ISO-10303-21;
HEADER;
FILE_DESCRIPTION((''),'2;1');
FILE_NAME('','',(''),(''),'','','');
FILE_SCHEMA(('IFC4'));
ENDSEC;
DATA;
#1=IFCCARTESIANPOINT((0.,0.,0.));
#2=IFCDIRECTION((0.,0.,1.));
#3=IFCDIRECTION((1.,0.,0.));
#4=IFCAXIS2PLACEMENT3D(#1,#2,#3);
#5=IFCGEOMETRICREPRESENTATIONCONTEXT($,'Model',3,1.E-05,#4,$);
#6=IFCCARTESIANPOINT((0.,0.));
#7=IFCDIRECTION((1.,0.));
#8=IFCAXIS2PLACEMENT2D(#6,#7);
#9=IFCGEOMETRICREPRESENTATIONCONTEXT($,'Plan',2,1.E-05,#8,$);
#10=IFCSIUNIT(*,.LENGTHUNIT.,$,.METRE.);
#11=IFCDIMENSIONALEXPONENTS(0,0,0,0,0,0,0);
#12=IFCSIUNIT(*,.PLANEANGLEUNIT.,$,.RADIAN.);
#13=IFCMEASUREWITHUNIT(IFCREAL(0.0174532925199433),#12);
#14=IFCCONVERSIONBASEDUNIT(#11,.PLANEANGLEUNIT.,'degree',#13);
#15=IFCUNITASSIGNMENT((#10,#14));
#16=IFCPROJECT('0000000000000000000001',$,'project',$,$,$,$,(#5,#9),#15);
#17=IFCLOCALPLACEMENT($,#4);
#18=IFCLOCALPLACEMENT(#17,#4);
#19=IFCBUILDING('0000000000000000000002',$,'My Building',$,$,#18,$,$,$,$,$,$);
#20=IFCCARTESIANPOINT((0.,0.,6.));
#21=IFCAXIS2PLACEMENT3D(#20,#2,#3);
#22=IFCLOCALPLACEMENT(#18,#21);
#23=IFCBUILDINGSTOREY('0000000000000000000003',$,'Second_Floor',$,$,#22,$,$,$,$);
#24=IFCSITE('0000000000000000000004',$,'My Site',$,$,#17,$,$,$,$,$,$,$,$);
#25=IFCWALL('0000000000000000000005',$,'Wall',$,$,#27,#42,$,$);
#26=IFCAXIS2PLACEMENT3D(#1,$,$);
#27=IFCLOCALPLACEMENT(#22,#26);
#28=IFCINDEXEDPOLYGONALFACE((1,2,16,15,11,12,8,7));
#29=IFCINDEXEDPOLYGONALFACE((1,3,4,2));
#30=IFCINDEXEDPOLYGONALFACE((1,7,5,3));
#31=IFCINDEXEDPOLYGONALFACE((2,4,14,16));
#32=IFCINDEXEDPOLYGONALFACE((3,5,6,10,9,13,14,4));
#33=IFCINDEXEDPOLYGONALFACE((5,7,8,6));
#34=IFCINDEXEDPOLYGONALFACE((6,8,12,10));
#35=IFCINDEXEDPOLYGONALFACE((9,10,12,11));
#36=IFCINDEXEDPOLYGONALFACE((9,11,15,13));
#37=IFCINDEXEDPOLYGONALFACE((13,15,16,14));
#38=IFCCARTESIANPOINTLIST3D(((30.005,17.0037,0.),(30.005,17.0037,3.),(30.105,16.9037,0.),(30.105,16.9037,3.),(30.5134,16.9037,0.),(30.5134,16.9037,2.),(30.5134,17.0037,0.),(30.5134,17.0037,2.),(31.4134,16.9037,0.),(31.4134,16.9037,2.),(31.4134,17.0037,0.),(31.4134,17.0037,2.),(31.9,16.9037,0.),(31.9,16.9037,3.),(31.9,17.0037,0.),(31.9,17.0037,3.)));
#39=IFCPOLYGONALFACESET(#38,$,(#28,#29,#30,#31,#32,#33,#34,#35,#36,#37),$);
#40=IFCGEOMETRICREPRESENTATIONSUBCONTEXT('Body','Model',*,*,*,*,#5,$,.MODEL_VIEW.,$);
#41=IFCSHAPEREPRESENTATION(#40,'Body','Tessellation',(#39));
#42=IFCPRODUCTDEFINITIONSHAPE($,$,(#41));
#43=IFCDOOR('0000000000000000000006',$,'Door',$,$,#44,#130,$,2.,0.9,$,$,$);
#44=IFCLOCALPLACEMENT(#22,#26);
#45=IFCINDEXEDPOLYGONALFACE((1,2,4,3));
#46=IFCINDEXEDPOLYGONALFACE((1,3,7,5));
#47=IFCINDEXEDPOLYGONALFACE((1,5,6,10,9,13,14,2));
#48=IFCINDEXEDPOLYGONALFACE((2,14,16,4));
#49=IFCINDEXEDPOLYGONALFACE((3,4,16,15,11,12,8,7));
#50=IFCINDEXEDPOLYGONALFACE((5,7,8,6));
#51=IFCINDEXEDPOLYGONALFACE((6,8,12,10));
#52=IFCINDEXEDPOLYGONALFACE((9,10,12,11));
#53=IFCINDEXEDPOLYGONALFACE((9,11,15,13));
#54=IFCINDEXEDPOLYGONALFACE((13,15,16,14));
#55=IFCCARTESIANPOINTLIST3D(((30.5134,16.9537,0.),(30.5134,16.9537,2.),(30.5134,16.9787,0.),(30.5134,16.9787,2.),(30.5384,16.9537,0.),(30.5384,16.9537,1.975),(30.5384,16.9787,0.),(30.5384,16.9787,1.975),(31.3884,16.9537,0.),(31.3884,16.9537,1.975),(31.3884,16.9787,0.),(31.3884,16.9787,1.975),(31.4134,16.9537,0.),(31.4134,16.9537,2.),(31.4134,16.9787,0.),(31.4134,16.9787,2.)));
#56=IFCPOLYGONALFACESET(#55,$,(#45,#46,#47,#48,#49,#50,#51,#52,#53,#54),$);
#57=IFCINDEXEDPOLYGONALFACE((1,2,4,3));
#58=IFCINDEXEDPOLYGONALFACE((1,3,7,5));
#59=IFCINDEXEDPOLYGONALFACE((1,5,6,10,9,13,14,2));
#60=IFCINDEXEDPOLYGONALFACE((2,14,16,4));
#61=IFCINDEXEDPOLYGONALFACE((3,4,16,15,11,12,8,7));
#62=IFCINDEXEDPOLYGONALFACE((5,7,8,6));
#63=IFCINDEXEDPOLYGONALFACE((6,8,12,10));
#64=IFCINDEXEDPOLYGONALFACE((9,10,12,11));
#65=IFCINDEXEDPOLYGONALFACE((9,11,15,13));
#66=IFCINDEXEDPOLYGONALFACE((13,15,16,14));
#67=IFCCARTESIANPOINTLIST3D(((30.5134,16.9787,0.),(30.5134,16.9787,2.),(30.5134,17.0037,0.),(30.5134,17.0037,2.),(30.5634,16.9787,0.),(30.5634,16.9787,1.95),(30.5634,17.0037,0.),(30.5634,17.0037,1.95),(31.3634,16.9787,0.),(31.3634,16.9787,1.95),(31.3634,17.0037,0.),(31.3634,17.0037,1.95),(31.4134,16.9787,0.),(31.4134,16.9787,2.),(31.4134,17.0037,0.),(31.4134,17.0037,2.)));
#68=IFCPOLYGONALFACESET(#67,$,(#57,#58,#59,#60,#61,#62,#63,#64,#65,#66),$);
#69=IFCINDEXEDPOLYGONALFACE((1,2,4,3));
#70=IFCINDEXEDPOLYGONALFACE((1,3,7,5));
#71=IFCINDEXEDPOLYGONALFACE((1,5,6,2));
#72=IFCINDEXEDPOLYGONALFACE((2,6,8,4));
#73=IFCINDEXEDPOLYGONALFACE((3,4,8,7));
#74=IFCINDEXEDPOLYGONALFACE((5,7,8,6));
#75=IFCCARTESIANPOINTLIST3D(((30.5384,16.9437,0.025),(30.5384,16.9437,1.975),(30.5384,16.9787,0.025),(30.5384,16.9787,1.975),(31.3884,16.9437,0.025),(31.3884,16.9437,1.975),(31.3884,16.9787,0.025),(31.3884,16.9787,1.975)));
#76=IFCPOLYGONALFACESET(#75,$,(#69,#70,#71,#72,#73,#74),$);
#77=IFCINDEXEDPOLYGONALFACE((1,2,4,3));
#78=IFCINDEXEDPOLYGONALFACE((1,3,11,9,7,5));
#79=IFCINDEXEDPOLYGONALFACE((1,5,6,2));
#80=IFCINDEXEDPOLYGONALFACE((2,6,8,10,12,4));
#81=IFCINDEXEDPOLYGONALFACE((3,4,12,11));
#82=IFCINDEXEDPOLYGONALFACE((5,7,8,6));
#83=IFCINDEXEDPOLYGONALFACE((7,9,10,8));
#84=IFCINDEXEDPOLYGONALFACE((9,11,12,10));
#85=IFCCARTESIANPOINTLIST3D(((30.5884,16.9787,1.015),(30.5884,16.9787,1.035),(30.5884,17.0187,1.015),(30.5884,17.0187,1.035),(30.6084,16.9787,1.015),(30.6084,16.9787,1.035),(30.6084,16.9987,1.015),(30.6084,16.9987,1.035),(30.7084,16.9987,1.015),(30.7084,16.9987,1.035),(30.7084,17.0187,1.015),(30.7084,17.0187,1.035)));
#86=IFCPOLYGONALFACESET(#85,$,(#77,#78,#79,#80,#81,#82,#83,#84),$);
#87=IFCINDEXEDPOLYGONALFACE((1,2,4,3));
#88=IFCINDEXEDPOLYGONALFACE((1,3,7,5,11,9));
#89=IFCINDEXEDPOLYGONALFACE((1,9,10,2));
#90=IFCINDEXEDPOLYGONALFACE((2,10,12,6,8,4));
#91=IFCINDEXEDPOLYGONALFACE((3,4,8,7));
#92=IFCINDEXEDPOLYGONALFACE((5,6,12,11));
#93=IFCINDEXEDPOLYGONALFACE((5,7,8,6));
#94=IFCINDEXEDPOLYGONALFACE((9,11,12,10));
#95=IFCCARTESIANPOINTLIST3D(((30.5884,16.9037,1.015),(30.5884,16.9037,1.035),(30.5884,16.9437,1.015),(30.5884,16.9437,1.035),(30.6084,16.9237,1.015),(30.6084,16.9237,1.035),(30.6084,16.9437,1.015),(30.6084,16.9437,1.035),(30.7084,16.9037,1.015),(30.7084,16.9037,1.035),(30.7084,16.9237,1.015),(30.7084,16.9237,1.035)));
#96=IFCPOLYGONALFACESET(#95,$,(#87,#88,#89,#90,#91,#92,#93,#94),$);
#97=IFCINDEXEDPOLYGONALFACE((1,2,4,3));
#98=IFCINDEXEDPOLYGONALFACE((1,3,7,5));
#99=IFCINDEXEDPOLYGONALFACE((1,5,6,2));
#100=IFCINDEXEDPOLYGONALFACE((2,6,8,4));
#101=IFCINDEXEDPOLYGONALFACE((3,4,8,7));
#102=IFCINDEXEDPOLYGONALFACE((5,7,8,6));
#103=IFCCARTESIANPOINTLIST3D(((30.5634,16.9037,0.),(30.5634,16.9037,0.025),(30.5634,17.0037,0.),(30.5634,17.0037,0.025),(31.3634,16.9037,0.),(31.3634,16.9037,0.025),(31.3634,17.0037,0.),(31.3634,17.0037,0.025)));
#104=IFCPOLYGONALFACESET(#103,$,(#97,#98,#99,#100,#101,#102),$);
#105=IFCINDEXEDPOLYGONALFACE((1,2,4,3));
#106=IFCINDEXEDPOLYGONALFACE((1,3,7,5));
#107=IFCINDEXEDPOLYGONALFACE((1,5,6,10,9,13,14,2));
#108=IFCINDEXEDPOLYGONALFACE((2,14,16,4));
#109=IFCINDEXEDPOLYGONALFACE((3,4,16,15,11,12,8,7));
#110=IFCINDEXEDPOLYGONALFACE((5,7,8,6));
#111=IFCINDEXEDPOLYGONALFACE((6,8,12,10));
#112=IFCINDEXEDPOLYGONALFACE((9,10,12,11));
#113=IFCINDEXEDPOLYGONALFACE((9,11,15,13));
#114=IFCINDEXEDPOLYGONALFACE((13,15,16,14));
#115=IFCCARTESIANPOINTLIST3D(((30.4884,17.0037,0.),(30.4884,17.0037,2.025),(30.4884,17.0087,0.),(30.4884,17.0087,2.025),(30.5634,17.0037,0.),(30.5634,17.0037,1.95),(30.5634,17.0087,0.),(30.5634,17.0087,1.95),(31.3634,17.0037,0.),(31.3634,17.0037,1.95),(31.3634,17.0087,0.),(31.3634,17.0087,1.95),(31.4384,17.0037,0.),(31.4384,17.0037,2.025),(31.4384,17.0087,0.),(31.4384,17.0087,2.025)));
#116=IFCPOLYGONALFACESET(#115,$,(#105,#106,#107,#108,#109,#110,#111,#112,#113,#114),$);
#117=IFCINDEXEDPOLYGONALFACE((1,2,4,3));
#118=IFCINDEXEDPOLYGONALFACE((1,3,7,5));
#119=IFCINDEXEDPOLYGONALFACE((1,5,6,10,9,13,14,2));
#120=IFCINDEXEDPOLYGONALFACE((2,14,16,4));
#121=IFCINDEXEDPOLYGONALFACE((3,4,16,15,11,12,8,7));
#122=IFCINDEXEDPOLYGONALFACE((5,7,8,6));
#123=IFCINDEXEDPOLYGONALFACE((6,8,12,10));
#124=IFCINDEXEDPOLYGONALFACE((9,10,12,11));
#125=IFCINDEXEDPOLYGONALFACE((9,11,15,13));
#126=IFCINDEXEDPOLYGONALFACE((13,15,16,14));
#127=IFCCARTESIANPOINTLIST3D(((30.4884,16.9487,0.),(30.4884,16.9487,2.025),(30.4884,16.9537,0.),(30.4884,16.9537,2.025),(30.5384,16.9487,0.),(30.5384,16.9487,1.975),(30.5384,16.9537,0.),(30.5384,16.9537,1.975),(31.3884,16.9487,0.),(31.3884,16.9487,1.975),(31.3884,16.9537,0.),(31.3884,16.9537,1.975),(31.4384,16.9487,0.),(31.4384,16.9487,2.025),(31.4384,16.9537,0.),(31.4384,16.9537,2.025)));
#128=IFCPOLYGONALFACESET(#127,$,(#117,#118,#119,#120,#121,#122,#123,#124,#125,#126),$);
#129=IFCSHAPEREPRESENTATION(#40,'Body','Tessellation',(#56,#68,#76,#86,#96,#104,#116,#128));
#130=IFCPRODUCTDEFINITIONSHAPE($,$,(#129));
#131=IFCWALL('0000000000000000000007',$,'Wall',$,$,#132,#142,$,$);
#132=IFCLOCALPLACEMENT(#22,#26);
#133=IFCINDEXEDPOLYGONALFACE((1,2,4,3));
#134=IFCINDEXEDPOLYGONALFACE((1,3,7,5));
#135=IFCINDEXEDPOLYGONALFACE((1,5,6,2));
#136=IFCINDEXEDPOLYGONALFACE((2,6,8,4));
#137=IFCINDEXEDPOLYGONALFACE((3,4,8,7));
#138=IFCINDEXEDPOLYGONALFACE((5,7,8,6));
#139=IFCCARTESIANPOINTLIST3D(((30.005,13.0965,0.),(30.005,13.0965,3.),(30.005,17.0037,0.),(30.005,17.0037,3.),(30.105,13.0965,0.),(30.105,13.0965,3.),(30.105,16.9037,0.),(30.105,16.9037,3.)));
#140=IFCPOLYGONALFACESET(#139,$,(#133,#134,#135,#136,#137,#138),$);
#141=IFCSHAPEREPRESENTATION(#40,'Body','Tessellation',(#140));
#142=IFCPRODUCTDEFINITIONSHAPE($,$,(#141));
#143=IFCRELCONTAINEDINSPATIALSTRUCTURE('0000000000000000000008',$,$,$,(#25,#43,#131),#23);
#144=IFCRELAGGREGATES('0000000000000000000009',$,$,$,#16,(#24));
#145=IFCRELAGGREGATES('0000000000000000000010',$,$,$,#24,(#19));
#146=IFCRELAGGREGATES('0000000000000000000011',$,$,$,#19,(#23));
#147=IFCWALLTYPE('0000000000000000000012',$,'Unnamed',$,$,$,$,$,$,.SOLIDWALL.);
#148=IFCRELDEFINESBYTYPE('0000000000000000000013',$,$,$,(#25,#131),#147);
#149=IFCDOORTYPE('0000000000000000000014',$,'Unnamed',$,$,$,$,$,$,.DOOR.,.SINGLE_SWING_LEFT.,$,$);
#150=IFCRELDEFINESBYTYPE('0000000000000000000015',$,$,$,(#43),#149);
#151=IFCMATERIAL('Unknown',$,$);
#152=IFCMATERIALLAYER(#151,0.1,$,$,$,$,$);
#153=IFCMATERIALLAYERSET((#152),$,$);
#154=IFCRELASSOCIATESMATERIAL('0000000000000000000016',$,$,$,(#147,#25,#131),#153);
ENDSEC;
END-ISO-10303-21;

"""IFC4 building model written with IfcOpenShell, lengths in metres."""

from ifc_helpers import new_model, entity, si_unit, converted_unit, frame, origin_with_axes, origin_2d_with_axis, place, context, subcontext, project, spatial, line, indexed_curve, outline, extrude, shape, source, transform, mapped, material, layer, layer_set, layer_usage, type_object, type_shapes, element, fill, save


model = new_model("IFC4")

# Units and contexts
model_context = context("Model", 3, precision=1e-05, world=origin_with_axes())
plan_context = context("Plan", 2, precision=1e-05, world=origin_2d_with_axis())
body_context_1 = subcontext(model_context, "Body", "Model", "MODEL_VIEW")
body_context_2 = subcontext(plan_context, "Body", "Plan", "PLAN_VIEW")
ifc_project = project(units=[si_unit("LENGTHUNIT", "METRE"), converted_unit("PLANEANGLEUNIT", "degree", entity("IfcReal", 0.0174532925199433), si_unit("PLANEANGLEUNIT", "RADIAN"), dimensions=[0, 0, 0, 0, 0, 0, 0])], contexts=[model_context, plan_context])

# Site, building, storey
site_placement = place(None, origin_with_axes())
site = spatial("IfcSite", under=ifc_project, at=site_placement, Name="My Site")
building_placement = place(site_placement, origin_with_axes())
building = spatial("IfcBuilding", under=site, at=building_placement, Name="My Building")
storey_placement = place(building_placement, frame((0.0, 0.0, 6.0), z_axis=(0.0, 0.0, 1.0), x_axis=(1.0, 0.0, 0.0)))
storey = spatial("IfcBuildingStorey", under=building, at=storey_placement, Name="Second_Floor")

# Shared definitions
ifc_material = material(Name="Unknown")
ifc_layer = layer(ifc_material, 0.1)
ifc_layer_set = layer_set([ifc_layer])
wall_type = type_object("IfcWallType", Name="Unnamed", PredefinedType="SOLIDWALL", material=ifc_layer_set)

# Shared definitions
shared_shape_1 = source(origin_with_axes(), body_context_1, "Body", "SweptSolid", [
    extrude(outline(indexed_curve([(0.0, 0.0), (0.9, 0.0), (0.9, 2.0), (0.0, 2.0)], segments=[line(1, 2, 3, 4, 1)])), frame((0.0, -0.6, 0.0), z_axis=(0.0, -1.0, 0.0), x_axis=(1.0, 0.0, 0.0)), (0.0, 0.0, -1.0), 1.2),
])
door_type = type_object("IfcDoorType", Name="Unnamed", OperationType="SINGLE_SWING_LEFT", PredefinedType="DOOR")
shared_shape_2 = source(origin_with_axes(), body_context_1, "Body", "SweptSolid", [
    extrude(outline(indexed_curve([(0.0, 0.0), (0.0, 2.0), (0.9, 2.0), (0.9, 0.0), (0.875, 0.0), (0.875, 1.975), (0.025, 1.975), (0.025, 0.0)], segments=[line(1, 2, 3, 4, 5, 6, 7, 8, 1)])), frame((0.0, 0.025, 0.0), z_axis=(0.0, -1.0, 0.0), x_axis=(1.0, 0.0, 0.0)), (0.0, 0.0, -1.0), 0.025),
    extrude(outline(indexed_curve([(0.0, 0.0), (0.0, 2.0), (0.9, 2.0), (0.9, 0.0), (0.85, 0.0), (0.85, 1.95), (0.05, 1.95), (0.05, 0.0)], segments=[line(1, 2, 3, 4, 5, 6, 7, 8, 1)])), frame((0.0, 0.0, 0.0), z_axis=(0.0, -1.0, 0.0), x_axis=(1.0, 0.0, 0.0)), (0.0, 0.0, -1.0), 0.025),
    extrude(outline(indexed_curve([(0.0, 0.0), (0.85, 0.0), (0.85, 0.035), (0.0, 0.035)], segments=[line(1, 2, 3, 4, 1)])), frame((0.025, 0.025, 0.025), z_axis=(0.0, 0.0, 1.0), x_axis=(1.0, 0.0, 0.0)), (0.0, 0.0, 1.0), 1.95),
    extrude(outline(indexed_curve([(0.0, 0.0), (0.0, -0.04), (-0.12, -0.04), (-0.12, -0.02), (-0.02, -0.02), (-0.02, 0.0)], segments=[line(1, 2, 3, 4, 5, 6, 1)])), frame((0.825, 0.025, 1.015), z_axis=(0.0, 0.0, 1.0), x_axis=(1.0, 0.0, 0.0)), (0.0, 0.0, 1.0), 0.02),
    extrude(outline(indexed_curve([(0.0, 0.0), (0.0, 0.04), (-0.12, 0.04), (-0.12, 0.02), (-0.02, 0.02), (-0.02, 0.0)], segments=[line(1, 2, 3, 4, 5, 6, 1)])), frame((0.825, 0.06, 1.015), z_axis=(0.0, 0.0, 1.0), x_axis=(1.0, 0.0, 0.0)), (0.0, 0.0, 1.0), 0.02),
    extrude(outline(indexed_curve([(0.0, 0.0), (0.8, 0.0), (0.8, 0.1), (0.0, 0.1)], segments=[line(1, 2, 3, 4, 1)])), frame((0.05, 0.0, 0.0), z_axis=(0.0, 0.0, 1.0), x_axis=(1.0, 0.0, 0.0)), (0.0, 0.0, 1.0), 0.025),
    extrude(outline(indexed_curve([(0.0, 0.0), (0.0, 2.025), (0.95, 2.025), (0.95, 0.0), (0.875, 0.0), (0.875, 1.95), (0.075, 1.95), (0.075, 0.0)], segments=[line(1, 2, 3, 4, 5, 6, 7, 8, 1)])), frame((-0.025, -0.005, 0.0), z_axis=(0.0, -1.0, 0.0), x_axis=(1.0, 0.0, 0.0)), (0.0, 0.0, -1.0), 0.005),
    extrude(outline(indexed_curve([(0.0, 0.0), (0.0, 2.025), (0.95, 2.025), (0.95, 0.0), (0.9, 0.0), (0.9, 1.975), (0.05, 1.975), (0.05, 0.0)], segments=[line(1, 2, 3, 4, 5, 6, 7, 8, 1)])), frame((-0.025, 0.05, 0.0), z_axis=(0.0, -1.0, 0.0), x_axis=(1.0, 0.0, 0.0)), (0.0, 0.0, -1.0), 0.005),
])
shared_shape_3 = source(origin_with_axes(), body_context_2, "Body", "Curve2D", [
    entity("IfcIndexedPolyCurve", entity("IfcCartesianPointList2D", [[0.0, 0.0], [0.0, 0.05], [0.025, 0.05], [0.025, 0.025], [0.05, 0.025], [0.05, 0.0]]), [entity("IfcLineIndex", [1, 2, 3, 4, 5, 6, 1])]),
    entity("IfcIndexedPolyCurve", entity("IfcCartesianPointList2D", [[0.9, 0.0], [0.9, 0.05], [0.875, 0.05], [0.875, 0.025], [0.85, 0.025], [0.85, 0.0]]), [entity("IfcLineIndex", [1, 2, 3, 4, 5, 6, 1])]),
    entity("IfcTrimmedCurve", entity("IfcEllipse", entity("IfcAxis2Placement2D", entity("IfcCartesianPoint", [0.06, 0.05]), entity("IfcDirection", [1.0, 0.0])), 0.815, 0.85), [entity("IfcCartesianPoint", [0.875, 0.05])], [entity("IfcCartesianPoint", [0.06, 0.9])], True, "CARTESIAN"),
    entity("IfcIndexedPolyCurve", entity("IfcCartesianPointList2D", [[0.025, 0.05], [0.06, 0.05], [0.06, 0.9], [0.025, 0.9]]), [entity("IfcLineIndex", [1, 2, 3, 4, 1])]),
])
type_shapes(door_type, [shared_shape_2, shared_shape_3])

# Wall, opening, door
ifc_layer_usage_1 = layer_usage(ifc_layer_set, "AXIS2", "POSITIVE", 0.0)
wall_1_placement = place(storey_placement, frame((31.9, 17.0037, 0.0), z_axis=(0.0, 0.0, 1.0), x_axis=(-1.0, 0.0, 0.0)))
wall_1 = element("IfcWall", 1, at=wall_1_placement, inside=storey, type_object=wall_type, material=ifc_layer_usage_1, Name="Wall", context=body_context_1, shape_type="SweptSolid", body=[
    extrude(outline(indexed_curve([(0.0, 0.0), (0.0, 0.1), (1.795, 0.1), (1.895, 0.0)], segments=[line(1, 2, 3, 4, 1)])), origin_with_axes(), (0.0, 0.0, 1.0), 3.0),
])
opening_1_placement = place(wall_1_placement, frame((0.4866, 0.0, 0.0), z_axis=(0.0, 0.0, 1.0), x_axis=(1.0, 0.0, 0.0)))
opening_1 = element("IfcOpeningElement", 2, at=opening_1_placement, cuts=wall_1, PredefinedType="OPENING", context=body_context_1, shape_type="MappedRepresentation", body=[
    mapped(shared_shape_1, transform((0.0, 0.0, 0.0), x_axis=(1.0, 0.0, 0.0), y_axis=(0.0, 1.0, 0.0), z_axis=(0.0, 0.0, 1.0), scale=1.0)),
])
door_1_placement = place(opening_1_placement, frame((0.0, 0.0, 0.0), z_axis=(0.0, 0.0, 1.0), x_axis=(1.0, 0.0, 0.0)))
door_1 = element("IfcDoor", 3, at=door_1_placement, inside=storey, type_object=door_type, Name="Door", OverallHeight=2.0, OverallWidth=0.9, shapes=[
    shape(body_context_1, "Body", "MappedRepresentation", [mapped(shared_shape_2, transform((0.0, 0.0, 0.0), x_axis=(1.0, 0.0, 0.0), y_axis=(0.0, 1.0, 0.0), z_axis=(0.0, 0.0, 1.0), scale=1.0))]),
    shape(body_context_2, "Body", "MappedRepresentation", [mapped(shared_shape_3, transform((0.0, 0.0, 0.0), x_axis=(1.0, 0.0, 0.0), y_axis=(0.0, 1.0, 0.0), z_axis=(0.0, 0.0, 1.0), scale=1.0))]),
])
fill(opening_1, door_1)

# Wall
ifc_layer_usage_2 = layer_usage(ifc_layer_set, "AXIS2", "POSITIVE", 0.0)
wall_2_placement = place(storey_placement, frame((30.005, 17.0037, 0.0), z_axis=(0.0, 0.0, 1.0), x_axis=(0.0, -1.0, 0.0)))
element("IfcWall", 4, at=wall_2_placement, inside=storey, type_object=wall_type, material=ifc_layer_usage_2, Name="Wall", context=body_context_1, shape_type="SweptSolid", body=[
    extrude(outline(indexed_curve([(0.0, 0.0), (0.1, 0.1), (3.9072, 0.1), (3.9072, 0.0)], segments=[line(1, 2, 3, 4, 1)])), origin_with_axes(), (0.0, 0.0, 1.0), 3.0),
])

save(model, "model.ifc")
